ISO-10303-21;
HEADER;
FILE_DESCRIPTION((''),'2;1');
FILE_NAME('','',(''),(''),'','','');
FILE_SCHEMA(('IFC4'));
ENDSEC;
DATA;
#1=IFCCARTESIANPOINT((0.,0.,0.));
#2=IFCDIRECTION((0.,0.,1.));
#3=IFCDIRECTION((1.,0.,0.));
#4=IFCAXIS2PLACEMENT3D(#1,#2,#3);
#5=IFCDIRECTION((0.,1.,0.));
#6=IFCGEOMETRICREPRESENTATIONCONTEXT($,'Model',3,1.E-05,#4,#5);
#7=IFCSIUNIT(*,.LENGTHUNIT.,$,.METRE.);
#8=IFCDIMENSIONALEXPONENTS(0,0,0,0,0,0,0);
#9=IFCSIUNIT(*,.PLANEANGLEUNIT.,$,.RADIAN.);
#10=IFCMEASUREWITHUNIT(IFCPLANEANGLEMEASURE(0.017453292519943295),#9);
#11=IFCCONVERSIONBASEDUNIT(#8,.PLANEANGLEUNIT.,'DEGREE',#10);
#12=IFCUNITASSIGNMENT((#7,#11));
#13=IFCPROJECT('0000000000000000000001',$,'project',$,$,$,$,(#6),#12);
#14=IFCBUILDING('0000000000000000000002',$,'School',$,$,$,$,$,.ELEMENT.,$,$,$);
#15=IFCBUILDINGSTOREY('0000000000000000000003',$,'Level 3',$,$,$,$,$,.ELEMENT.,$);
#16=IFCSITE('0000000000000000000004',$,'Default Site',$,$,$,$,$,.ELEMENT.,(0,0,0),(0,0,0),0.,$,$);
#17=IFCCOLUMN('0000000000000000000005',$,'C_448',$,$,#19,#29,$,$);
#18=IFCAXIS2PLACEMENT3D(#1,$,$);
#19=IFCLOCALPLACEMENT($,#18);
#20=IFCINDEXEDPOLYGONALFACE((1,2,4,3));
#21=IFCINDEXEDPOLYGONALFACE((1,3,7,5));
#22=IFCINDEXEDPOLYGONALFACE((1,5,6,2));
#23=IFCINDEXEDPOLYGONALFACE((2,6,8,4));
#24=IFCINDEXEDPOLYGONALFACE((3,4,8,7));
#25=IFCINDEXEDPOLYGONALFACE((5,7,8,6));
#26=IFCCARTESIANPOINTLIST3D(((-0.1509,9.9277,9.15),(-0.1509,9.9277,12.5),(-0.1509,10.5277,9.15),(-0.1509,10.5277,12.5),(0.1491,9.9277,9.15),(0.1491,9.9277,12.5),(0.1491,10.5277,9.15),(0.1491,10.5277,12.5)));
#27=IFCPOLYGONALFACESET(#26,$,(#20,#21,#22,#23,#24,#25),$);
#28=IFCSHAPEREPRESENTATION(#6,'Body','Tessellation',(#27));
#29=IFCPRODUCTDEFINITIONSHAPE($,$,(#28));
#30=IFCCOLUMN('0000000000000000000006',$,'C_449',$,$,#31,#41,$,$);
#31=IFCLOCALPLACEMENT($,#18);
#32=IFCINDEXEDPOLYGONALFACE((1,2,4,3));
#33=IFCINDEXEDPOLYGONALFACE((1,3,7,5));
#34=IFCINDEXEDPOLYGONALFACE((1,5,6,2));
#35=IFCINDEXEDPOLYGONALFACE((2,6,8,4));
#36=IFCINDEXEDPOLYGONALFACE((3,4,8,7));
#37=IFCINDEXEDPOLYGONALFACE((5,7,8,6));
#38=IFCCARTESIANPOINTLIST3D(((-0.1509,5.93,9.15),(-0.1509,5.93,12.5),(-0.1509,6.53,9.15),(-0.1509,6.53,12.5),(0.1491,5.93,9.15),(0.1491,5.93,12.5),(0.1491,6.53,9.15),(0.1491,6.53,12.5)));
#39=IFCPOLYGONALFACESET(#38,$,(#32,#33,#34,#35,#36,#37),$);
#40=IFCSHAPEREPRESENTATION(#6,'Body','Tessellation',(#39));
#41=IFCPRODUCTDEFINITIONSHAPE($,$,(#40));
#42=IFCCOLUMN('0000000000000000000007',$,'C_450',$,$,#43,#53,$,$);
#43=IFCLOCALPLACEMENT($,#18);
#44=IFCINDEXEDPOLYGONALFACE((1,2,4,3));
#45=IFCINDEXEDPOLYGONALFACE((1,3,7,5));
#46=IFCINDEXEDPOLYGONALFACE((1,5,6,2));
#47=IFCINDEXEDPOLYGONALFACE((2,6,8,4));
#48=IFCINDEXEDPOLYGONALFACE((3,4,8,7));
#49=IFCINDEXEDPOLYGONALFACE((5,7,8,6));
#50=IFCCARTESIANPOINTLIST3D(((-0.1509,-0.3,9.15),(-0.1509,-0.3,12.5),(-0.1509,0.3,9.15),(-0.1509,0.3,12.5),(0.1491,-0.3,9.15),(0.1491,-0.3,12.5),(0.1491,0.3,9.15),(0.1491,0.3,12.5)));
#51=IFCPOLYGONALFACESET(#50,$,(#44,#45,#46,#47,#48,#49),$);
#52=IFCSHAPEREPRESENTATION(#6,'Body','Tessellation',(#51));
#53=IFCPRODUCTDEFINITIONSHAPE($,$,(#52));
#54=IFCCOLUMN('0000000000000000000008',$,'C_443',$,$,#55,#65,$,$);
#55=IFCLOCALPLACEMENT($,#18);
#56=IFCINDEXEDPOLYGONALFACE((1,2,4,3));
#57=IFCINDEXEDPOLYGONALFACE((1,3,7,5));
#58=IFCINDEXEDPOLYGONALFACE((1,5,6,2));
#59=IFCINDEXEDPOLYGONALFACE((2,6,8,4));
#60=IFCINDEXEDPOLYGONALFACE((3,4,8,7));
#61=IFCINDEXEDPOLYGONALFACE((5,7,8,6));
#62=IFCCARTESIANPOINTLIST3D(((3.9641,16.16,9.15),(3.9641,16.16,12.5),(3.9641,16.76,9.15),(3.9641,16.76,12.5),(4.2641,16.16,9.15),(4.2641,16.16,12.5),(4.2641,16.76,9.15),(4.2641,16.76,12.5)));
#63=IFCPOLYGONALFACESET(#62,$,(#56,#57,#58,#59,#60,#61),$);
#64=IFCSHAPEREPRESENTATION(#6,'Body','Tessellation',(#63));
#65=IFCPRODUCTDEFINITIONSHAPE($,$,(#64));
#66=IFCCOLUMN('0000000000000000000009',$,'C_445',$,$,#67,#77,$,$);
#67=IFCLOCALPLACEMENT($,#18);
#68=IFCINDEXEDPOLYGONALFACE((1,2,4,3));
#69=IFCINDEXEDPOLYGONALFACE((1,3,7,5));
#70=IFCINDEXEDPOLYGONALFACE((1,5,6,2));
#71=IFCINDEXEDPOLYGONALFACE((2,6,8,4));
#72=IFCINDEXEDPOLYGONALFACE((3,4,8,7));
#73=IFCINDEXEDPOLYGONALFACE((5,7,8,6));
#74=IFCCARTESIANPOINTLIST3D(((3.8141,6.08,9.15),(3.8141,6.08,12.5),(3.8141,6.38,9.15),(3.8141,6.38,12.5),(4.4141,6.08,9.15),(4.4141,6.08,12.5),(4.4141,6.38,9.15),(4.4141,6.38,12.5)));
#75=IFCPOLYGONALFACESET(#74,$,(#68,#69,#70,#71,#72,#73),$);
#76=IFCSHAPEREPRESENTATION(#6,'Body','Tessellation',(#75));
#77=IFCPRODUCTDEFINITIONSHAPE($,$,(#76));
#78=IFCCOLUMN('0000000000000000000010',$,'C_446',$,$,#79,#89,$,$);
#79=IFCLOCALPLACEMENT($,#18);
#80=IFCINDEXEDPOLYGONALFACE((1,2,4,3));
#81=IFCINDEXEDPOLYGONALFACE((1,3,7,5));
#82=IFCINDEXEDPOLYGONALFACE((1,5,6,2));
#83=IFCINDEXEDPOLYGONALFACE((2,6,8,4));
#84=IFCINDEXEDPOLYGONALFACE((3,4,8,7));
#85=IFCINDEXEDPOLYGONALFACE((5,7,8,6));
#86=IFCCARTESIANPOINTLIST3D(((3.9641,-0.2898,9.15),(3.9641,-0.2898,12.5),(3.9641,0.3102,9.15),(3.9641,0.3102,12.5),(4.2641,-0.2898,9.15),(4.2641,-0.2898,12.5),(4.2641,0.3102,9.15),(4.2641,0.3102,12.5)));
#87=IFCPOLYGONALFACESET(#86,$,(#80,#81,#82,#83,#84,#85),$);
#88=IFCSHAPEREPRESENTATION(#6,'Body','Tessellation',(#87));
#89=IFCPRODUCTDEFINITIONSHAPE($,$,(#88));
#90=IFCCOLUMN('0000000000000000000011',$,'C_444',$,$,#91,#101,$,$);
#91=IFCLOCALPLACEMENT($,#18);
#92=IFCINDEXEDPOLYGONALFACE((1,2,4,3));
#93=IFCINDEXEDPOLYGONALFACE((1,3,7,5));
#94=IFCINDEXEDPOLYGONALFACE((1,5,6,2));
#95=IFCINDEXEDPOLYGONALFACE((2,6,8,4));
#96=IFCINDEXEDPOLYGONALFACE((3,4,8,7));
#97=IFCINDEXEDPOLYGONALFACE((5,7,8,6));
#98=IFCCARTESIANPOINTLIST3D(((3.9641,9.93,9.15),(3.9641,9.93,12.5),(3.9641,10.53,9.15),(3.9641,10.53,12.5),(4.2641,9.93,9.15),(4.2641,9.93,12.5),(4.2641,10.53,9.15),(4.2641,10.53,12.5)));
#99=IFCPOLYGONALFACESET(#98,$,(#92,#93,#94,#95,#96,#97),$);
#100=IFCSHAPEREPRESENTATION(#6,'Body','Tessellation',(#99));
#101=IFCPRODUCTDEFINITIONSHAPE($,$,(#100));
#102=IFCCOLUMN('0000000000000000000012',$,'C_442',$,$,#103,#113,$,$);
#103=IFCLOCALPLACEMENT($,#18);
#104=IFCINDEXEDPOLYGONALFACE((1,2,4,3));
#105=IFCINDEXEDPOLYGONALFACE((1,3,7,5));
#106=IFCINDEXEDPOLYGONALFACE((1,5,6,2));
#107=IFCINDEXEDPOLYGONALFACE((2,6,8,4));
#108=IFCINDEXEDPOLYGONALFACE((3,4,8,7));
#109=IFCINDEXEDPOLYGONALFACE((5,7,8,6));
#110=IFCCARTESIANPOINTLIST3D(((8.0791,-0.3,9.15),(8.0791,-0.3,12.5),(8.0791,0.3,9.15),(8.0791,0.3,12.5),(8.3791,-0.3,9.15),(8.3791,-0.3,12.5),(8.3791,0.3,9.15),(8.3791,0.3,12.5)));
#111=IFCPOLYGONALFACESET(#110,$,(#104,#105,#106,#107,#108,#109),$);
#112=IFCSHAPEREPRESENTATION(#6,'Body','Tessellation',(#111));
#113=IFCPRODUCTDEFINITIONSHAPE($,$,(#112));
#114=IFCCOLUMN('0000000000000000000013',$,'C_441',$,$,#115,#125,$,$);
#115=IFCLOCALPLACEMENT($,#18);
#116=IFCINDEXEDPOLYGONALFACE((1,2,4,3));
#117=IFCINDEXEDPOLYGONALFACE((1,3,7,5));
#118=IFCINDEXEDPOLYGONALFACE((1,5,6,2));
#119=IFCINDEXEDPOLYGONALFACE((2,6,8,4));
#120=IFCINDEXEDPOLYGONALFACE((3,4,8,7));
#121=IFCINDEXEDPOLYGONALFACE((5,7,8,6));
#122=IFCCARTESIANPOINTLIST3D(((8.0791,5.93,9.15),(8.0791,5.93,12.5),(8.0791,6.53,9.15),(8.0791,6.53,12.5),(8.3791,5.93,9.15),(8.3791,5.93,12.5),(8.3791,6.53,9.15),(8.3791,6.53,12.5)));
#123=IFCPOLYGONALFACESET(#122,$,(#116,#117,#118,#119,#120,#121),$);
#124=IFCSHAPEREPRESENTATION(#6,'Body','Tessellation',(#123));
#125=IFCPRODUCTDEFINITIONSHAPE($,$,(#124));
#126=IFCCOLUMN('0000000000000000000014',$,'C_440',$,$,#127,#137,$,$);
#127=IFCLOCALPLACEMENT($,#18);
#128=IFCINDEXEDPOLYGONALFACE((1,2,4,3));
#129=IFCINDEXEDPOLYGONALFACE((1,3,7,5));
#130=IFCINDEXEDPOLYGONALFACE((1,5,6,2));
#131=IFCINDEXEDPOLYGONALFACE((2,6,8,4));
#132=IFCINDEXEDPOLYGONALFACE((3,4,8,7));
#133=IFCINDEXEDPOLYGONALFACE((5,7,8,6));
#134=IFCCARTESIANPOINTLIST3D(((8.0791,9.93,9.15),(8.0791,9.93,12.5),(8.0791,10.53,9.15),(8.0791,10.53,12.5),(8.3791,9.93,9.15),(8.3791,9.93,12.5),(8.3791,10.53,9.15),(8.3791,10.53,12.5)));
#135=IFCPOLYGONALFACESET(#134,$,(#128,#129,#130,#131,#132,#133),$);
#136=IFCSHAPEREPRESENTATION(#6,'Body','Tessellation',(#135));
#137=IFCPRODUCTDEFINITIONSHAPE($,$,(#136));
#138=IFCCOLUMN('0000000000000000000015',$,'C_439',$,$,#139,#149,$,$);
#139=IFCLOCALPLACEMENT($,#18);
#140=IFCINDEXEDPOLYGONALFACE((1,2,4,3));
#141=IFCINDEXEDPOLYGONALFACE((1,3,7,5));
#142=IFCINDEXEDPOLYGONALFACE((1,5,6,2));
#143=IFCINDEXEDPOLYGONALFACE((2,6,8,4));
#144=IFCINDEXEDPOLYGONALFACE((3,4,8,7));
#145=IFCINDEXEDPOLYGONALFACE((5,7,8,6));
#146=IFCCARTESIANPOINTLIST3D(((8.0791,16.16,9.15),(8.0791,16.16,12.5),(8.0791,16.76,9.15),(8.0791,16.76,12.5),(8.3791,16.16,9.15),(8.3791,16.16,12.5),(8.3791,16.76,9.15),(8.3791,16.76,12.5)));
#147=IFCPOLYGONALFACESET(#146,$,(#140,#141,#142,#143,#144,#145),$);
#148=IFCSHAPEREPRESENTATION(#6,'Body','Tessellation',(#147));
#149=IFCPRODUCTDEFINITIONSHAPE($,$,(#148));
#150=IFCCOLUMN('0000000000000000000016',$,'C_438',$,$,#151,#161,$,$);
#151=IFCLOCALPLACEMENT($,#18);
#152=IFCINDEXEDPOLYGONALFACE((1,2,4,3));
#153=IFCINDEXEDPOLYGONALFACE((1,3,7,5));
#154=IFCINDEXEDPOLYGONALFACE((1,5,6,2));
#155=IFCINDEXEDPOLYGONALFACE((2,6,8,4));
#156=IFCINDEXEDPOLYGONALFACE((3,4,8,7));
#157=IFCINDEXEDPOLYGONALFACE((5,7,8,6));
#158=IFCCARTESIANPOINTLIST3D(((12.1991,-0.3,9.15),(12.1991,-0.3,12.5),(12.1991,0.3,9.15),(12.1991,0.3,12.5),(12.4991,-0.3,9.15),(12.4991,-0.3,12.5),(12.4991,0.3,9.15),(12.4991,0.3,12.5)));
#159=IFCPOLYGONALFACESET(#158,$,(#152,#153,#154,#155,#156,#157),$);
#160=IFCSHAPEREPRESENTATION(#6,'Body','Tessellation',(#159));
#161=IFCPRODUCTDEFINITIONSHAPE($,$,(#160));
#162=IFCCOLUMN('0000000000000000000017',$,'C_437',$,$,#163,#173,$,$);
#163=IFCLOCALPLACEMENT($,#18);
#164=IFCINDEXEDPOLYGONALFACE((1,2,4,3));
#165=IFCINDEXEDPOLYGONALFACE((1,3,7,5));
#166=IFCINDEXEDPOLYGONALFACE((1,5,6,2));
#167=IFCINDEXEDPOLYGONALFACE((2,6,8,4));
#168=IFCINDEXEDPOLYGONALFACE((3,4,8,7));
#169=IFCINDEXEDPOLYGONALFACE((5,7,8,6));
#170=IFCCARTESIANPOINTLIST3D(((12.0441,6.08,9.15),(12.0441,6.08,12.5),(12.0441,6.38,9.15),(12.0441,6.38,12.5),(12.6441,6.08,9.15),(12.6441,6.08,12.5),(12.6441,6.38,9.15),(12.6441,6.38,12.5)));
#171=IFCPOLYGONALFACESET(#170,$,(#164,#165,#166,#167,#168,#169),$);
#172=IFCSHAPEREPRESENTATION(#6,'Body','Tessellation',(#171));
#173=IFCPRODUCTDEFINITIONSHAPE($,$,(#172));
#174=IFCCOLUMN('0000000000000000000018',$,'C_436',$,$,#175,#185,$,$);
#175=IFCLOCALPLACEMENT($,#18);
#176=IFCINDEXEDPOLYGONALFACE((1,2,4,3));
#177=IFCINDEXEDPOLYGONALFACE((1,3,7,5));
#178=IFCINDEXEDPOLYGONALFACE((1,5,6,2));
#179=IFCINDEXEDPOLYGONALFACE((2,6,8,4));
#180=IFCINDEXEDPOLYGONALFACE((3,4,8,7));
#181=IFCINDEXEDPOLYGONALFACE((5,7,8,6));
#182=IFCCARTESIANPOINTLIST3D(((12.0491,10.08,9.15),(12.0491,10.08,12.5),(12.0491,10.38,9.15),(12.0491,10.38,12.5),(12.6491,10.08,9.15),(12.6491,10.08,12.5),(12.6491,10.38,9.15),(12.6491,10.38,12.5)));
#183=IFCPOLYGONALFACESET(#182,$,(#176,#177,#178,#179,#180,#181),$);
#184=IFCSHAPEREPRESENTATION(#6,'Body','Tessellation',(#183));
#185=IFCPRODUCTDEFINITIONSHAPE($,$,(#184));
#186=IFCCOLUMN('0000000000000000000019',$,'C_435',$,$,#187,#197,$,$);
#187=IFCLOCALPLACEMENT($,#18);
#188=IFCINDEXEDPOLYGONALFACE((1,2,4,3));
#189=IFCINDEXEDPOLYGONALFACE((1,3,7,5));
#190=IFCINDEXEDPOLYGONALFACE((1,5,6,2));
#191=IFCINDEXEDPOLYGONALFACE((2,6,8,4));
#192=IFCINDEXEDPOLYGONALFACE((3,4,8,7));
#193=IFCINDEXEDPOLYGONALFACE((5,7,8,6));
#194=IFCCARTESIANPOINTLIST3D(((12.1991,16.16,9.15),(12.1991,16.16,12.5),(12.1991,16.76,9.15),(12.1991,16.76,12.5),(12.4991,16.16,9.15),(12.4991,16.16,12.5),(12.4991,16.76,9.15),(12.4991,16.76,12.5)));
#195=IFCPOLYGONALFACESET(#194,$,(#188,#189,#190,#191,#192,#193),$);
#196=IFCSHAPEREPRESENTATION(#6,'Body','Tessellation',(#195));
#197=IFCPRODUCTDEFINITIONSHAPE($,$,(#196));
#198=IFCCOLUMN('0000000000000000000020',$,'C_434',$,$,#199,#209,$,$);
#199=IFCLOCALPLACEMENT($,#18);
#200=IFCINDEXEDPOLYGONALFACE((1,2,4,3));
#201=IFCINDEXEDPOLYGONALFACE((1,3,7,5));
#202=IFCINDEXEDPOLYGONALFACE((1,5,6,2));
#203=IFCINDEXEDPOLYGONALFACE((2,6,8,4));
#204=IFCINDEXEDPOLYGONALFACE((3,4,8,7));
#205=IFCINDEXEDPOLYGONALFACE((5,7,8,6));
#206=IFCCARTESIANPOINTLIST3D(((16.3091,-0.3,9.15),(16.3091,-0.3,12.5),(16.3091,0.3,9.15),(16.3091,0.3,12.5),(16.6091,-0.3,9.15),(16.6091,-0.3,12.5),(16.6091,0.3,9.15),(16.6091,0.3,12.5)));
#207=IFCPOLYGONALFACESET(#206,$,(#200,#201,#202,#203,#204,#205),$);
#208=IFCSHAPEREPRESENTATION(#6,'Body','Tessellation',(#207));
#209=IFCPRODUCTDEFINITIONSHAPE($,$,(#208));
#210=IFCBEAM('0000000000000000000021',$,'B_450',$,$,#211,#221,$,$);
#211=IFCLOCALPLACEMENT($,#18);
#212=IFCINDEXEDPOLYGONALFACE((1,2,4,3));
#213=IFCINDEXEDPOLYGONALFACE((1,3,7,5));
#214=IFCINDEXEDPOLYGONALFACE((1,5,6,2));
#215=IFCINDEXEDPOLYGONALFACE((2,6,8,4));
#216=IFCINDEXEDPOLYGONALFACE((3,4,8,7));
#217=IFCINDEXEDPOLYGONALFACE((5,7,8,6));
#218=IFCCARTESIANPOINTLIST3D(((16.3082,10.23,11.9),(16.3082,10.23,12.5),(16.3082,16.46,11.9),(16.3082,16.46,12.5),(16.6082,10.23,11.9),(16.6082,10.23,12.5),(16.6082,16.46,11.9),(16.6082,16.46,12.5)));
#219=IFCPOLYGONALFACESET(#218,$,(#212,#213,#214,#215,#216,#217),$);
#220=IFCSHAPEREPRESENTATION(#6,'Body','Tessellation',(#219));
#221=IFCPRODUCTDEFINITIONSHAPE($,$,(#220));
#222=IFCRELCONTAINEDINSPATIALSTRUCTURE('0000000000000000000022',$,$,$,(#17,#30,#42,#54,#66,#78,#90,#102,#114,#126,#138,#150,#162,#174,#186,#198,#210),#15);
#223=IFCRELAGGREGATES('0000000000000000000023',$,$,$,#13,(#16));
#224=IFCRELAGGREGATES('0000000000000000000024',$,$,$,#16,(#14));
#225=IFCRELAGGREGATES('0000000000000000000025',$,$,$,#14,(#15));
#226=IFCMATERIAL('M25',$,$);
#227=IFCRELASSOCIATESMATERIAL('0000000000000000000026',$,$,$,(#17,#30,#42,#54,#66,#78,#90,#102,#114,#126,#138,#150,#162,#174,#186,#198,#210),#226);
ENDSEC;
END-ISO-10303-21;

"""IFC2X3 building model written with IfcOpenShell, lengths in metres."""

from ifc_helpers import new_model, entity, si_unit, converted_unit, direction, frame, frame_2d, origin_with_axes, place, context, project, spatial, rectangle, extrude, material, element, save


model = new_model("IFC2X3")

# Units and contexts
model_context = context("Model", 3, precision=1e-05, world=origin_with_axes(), true_north=direction((0.0, 1.0, 0.0)))
ifc_project = project(units=[si_unit("LENGTHUNIT", "METRE"), converted_unit("PLANEANGLEUNIT", "DEGREE", entity("IfcPlaneAngleMeasure", 0.017453292519943295), si_unit("PLANEANGLEUNIT", "RADIAN"), dimensions=[0, 0, 0, 0, 0, 0, 0])], contexts=[model_context])

# Site, building, storey
site = spatial("IfcSite", under=ifc_project, Name="Default Site", CompositionType="ELEMENT", RefLatitude=(0, 0, 0), RefLongitude=(0, 0, 0), RefElevation=0.0)
building = spatial("IfcBuilding", under=site, Name="School", CompositionType="ELEMENT")
storey = spatial("IfcBuildingStorey", under=building, Name="Level 3", CompositionType="ELEMENT")

# Columns
ifc_material = material(Name="M25")
placement = place(None, origin_with_axes())
element("IfcColumn", 1, at=placement, inside=storey, material=ifc_material, Name="C_448", context=model_context, shape_type="SweptSolid", body=[
    extrude(rectangle(XDim=0.3, YDim=0.6, at=frame_2d((0.0, 0.0), x_axis=(1.0, 0.0, 0.0))), frame((-0.0009, 10.2277, 9.15), z_axis=(0.0, 0.0, 1.0), x_axis=(1.0, 0.0, 0.0)), (0.0, 0.0, 1.0), 3.35),
])
element("IfcColumn", 2, at=placement, inside=storey, material=ifc_material, Name="C_449", context=model_context, shape_type="SweptSolid", body=[
    extrude(rectangle(XDim=0.3, YDim=0.6, at=frame_2d((0.0, 0.0), x_axis=(1.0, 0.0, 0.0))), frame((-0.0009, 6.23, 9.15), z_axis=(0.0, 0.0, 1.0), x_axis=(1.0, 0.0, 0.0)), (0.0, 0.0, 1.0), 3.35),
])
element("IfcColumn", 3, at=placement, inside=storey, material=ifc_material, Name="C_450", context=model_context, shape_type="SweptSolid", body=[
    extrude(rectangle(XDim=0.3, YDim=0.6, at=frame_2d((0.0, 0.0), x_axis=(1.0, 0.0, 0.0))), frame((-0.0009, 0.0, 9.15), z_axis=(0.0, 0.0, 1.0), x_axis=(1.0, 0.0, 0.0)), (0.0, 0.0, 1.0), 3.35),
])
element("IfcColumn", 4, at=placement, inside=storey, material=ifc_material, Name="C_443", context=model_context, shape_type="SweptSolid", body=[
    extrude(rectangle(XDim=0.3, YDim=0.6, at=frame_2d((0.0, 0.0), x_axis=(1.0, 0.0, 0.0))), frame((4.1141, 16.46, 9.15), z_axis=(0.0, 0.0, 1.0), x_axis=(1.0, 0.0, 0.0)), (0.0, 0.0, 1.0), 3.35),
])
element("IfcColumn", 5, at=placement, inside=storey, material=ifc_material, Name="C_445", context=model_context, shape_type="SweptSolid", body=[
    extrude(rectangle(XDim=0.6, YDim=0.3, at=frame_2d((0.0, 0.0), x_axis=(1.0, 0.0, 0.0))), frame((4.1141, 6.23, 9.15), z_axis=(0.0, 0.0, 1.0), x_axis=(1.0, 0.0, 0.0)), (0.0, 0.0, 1.0), 3.35),
])
element("IfcColumn", 6, at=placement, inside=storey, material=ifc_material, Name="C_446", context=model_context, shape_type="SweptSolid", body=[
    extrude(rectangle(XDim=0.3, YDim=0.6, at=frame_2d((0.0, 0.0), x_axis=(1.0, 0.0, 0.0))), frame((4.1141, 0.0102, 9.15), z_axis=(0.0, 0.0, 1.0), x_axis=(1.0, 0.0, 0.0)), (0.0, 0.0, 1.0), 3.35),
])
element("IfcColumn", 7, at=placement, inside=storey, material=ifc_material, Name="C_444", context=model_context, shape_type="SweptSolid", body=[
    extrude(rectangle(XDim=0.3, YDim=0.6, at=frame_2d((0.0, 0.0), x_axis=(1.0, 0.0, 0.0))), frame((4.1141, 10.23, 9.15), z_axis=(0.0, 0.0, 1.0), x_axis=(1.0, 0.0, 0.0)), (0.0, 0.0, 1.0), 3.35),
])
element("IfcColumn", 8, at=placement, inside=storey, material=ifc_material, Name="C_442", context=model_context, shape_type="SweptSolid", body=[
    extrude(rectangle(XDim=0.3, YDim=0.6, at=frame_2d((0.0, 0.0), x_axis=(1.0, 0.0, 0.0))), frame((8.2291, 0.0, 9.15), z_axis=(0.0, 0.0, 1.0), x_axis=(1.0, 0.0, 0.0)), (0.0, 0.0, 1.0), 3.35),
])
element("IfcColumn", 9, at=placement, inside=storey, material=ifc_material, Name="C_441", context=model_context, shape_type="SweptSolid", body=[
    extrude(rectangle(XDim=0.3, YDim=0.6, at=frame_2d((0.0, 0.0), x_axis=(1.0, 0.0, 0.0))), frame((8.2291, 6.23, 9.15), z_axis=(0.0, 0.0, 1.0), x_axis=(1.0, 0.0, 0.0)), (0.0, 0.0, 1.0), 3.35),
])
element("IfcColumn", 10, at=placement, inside=storey, material=ifc_material, Name="C_440", context=model_context, shape_type="SweptSolid", body=[
    extrude(rectangle(XDim=0.3, YDim=0.6, at=frame_2d((0.0, 0.0), x_axis=(1.0, 0.0, 0.0))), frame((8.2291, 10.23, 9.15), z_axis=(0.0, 0.0, 1.0), x_axis=(1.0, 0.0, 0.0)), (0.0, 0.0, 1.0), 3.35),
])
element("IfcColumn", 11, at=placement, inside=storey, material=ifc_material, Name="C_439", context=model_context, shape_type="SweptSolid", body=[
    extrude(rectangle(XDim=0.3, YDim=0.6, at=frame_2d((0.0, 0.0), x_axis=(1.0, 0.0, 0.0))), frame((8.2291, 16.46, 9.15), z_axis=(0.0, 0.0, 1.0), x_axis=(1.0, 0.0, 0.0)), (0.0, 0.0, 1.0), 3.35),
])
element("IfcColumn", 12, at=placement, inside=storey, material=ifc_material, Name="C_438", context=model_context, shape_type="SweptSolid", body=[
    extrude(rectangle(XDim=0.3, YDim=0.6, at=frame_2d((0.0, 0.0), x_axis=(1.0, 0.0, 0.0))), frame((12.3491, 0.0, 9.15), z_axis=(0.0, 0.0, 1.0), x_axis=(1.0, 0.0, 0.0)), (0.0, 0.0, 1.0), 3.35),
])
element("IfcColumn", 13, at=placement, inside=storey, material=ifc_material, Name="C_437", context=model_context, shape_type="SweptSolid", body=[
    extrude(rectangle(XDim=0.6, YDim=0.3, at=frame_2d((0.0, 0.0), x_axis=(1.0, 0.0, 0.0))), frame((12.3441, 6.23, 9.15), z_axis=(0.0, 0.0, 1.0), x_axis=(1.0, 0.0, 0.0)), (0.0, 0.0, 1.0), 3.35),
])
element("IfcColumn", 14, at=placement, inside=storey, material=ifc_material, Name="C_436", context=model_context, shape_type="SweptSolid", body=[
    extrude(rectangle(XDim=0.6, YDim=0.3, at=frame_2d((0.0, 0.0), x_axis=(1.0, 0.0, 0.0))), frame((12.3491, 10.23, 9.15), z_axis=(0.0, 0.0, 1.0), x_axis=(1.0, 0.0, 0.0)), (0.0, 0.0, 1.0), 3.35),
])
element("IfcColumn", 15, at=placement, inside=storey, material=ifc_material, Name="C_435", context=model_context, shape_type="SweptSolid", body=[
    extrude(rectangle(XDim=0.3, YDim=0.6, at=frame_2d((0.0, 0.0), x_axis=(1.0, 0.0, 0.0))), frame((12.3491, 16.46, 9.15), z_axis=(0.0, 0.0, 1.0), x_axis=(1.0, 0.0, 0.0)), (0.0, 0.0, 1.0), 3.35),
])
element("IfcColumn", 16, at=placement, inside=storey, material=ifc_material, Name="C_434", context=model_context, shape_type="SweptSolid", body=[
    extrude(rectangle(XDim=0.3, YDim=0.6, at=frame_2d((0.0, 0.0), x_axis=(1.0, 0.0, 0.0))), frame((16.4591, 0.0, 9.15), z_axis=(0.0, 0.0, 1.0), x_axis=(1.0, 0.0, 0.0)), (0.0, 0.0, 1.0), 3.35),
])

# Beam
element("IfcBeam", 17, at=placement, inside=storey, material=ifc_material, Name="B_450", context=model_context, shape_type="SweptSolid", body=[
    extrude(rectangle(XDim=0.3, YDim=0.6, at=frame_2d((0.0, 0.0), x_axis=(0.0, 1.0, 0.0))), frame((16.4582, 10.23, 12.2), z_axis=(0.0, 1.0, 0.0), x_axis=(0.0, 0.0, -1.0)), (0.0, 0.0, 1.0), 6.23),
])

save(model, "model.ifc")
